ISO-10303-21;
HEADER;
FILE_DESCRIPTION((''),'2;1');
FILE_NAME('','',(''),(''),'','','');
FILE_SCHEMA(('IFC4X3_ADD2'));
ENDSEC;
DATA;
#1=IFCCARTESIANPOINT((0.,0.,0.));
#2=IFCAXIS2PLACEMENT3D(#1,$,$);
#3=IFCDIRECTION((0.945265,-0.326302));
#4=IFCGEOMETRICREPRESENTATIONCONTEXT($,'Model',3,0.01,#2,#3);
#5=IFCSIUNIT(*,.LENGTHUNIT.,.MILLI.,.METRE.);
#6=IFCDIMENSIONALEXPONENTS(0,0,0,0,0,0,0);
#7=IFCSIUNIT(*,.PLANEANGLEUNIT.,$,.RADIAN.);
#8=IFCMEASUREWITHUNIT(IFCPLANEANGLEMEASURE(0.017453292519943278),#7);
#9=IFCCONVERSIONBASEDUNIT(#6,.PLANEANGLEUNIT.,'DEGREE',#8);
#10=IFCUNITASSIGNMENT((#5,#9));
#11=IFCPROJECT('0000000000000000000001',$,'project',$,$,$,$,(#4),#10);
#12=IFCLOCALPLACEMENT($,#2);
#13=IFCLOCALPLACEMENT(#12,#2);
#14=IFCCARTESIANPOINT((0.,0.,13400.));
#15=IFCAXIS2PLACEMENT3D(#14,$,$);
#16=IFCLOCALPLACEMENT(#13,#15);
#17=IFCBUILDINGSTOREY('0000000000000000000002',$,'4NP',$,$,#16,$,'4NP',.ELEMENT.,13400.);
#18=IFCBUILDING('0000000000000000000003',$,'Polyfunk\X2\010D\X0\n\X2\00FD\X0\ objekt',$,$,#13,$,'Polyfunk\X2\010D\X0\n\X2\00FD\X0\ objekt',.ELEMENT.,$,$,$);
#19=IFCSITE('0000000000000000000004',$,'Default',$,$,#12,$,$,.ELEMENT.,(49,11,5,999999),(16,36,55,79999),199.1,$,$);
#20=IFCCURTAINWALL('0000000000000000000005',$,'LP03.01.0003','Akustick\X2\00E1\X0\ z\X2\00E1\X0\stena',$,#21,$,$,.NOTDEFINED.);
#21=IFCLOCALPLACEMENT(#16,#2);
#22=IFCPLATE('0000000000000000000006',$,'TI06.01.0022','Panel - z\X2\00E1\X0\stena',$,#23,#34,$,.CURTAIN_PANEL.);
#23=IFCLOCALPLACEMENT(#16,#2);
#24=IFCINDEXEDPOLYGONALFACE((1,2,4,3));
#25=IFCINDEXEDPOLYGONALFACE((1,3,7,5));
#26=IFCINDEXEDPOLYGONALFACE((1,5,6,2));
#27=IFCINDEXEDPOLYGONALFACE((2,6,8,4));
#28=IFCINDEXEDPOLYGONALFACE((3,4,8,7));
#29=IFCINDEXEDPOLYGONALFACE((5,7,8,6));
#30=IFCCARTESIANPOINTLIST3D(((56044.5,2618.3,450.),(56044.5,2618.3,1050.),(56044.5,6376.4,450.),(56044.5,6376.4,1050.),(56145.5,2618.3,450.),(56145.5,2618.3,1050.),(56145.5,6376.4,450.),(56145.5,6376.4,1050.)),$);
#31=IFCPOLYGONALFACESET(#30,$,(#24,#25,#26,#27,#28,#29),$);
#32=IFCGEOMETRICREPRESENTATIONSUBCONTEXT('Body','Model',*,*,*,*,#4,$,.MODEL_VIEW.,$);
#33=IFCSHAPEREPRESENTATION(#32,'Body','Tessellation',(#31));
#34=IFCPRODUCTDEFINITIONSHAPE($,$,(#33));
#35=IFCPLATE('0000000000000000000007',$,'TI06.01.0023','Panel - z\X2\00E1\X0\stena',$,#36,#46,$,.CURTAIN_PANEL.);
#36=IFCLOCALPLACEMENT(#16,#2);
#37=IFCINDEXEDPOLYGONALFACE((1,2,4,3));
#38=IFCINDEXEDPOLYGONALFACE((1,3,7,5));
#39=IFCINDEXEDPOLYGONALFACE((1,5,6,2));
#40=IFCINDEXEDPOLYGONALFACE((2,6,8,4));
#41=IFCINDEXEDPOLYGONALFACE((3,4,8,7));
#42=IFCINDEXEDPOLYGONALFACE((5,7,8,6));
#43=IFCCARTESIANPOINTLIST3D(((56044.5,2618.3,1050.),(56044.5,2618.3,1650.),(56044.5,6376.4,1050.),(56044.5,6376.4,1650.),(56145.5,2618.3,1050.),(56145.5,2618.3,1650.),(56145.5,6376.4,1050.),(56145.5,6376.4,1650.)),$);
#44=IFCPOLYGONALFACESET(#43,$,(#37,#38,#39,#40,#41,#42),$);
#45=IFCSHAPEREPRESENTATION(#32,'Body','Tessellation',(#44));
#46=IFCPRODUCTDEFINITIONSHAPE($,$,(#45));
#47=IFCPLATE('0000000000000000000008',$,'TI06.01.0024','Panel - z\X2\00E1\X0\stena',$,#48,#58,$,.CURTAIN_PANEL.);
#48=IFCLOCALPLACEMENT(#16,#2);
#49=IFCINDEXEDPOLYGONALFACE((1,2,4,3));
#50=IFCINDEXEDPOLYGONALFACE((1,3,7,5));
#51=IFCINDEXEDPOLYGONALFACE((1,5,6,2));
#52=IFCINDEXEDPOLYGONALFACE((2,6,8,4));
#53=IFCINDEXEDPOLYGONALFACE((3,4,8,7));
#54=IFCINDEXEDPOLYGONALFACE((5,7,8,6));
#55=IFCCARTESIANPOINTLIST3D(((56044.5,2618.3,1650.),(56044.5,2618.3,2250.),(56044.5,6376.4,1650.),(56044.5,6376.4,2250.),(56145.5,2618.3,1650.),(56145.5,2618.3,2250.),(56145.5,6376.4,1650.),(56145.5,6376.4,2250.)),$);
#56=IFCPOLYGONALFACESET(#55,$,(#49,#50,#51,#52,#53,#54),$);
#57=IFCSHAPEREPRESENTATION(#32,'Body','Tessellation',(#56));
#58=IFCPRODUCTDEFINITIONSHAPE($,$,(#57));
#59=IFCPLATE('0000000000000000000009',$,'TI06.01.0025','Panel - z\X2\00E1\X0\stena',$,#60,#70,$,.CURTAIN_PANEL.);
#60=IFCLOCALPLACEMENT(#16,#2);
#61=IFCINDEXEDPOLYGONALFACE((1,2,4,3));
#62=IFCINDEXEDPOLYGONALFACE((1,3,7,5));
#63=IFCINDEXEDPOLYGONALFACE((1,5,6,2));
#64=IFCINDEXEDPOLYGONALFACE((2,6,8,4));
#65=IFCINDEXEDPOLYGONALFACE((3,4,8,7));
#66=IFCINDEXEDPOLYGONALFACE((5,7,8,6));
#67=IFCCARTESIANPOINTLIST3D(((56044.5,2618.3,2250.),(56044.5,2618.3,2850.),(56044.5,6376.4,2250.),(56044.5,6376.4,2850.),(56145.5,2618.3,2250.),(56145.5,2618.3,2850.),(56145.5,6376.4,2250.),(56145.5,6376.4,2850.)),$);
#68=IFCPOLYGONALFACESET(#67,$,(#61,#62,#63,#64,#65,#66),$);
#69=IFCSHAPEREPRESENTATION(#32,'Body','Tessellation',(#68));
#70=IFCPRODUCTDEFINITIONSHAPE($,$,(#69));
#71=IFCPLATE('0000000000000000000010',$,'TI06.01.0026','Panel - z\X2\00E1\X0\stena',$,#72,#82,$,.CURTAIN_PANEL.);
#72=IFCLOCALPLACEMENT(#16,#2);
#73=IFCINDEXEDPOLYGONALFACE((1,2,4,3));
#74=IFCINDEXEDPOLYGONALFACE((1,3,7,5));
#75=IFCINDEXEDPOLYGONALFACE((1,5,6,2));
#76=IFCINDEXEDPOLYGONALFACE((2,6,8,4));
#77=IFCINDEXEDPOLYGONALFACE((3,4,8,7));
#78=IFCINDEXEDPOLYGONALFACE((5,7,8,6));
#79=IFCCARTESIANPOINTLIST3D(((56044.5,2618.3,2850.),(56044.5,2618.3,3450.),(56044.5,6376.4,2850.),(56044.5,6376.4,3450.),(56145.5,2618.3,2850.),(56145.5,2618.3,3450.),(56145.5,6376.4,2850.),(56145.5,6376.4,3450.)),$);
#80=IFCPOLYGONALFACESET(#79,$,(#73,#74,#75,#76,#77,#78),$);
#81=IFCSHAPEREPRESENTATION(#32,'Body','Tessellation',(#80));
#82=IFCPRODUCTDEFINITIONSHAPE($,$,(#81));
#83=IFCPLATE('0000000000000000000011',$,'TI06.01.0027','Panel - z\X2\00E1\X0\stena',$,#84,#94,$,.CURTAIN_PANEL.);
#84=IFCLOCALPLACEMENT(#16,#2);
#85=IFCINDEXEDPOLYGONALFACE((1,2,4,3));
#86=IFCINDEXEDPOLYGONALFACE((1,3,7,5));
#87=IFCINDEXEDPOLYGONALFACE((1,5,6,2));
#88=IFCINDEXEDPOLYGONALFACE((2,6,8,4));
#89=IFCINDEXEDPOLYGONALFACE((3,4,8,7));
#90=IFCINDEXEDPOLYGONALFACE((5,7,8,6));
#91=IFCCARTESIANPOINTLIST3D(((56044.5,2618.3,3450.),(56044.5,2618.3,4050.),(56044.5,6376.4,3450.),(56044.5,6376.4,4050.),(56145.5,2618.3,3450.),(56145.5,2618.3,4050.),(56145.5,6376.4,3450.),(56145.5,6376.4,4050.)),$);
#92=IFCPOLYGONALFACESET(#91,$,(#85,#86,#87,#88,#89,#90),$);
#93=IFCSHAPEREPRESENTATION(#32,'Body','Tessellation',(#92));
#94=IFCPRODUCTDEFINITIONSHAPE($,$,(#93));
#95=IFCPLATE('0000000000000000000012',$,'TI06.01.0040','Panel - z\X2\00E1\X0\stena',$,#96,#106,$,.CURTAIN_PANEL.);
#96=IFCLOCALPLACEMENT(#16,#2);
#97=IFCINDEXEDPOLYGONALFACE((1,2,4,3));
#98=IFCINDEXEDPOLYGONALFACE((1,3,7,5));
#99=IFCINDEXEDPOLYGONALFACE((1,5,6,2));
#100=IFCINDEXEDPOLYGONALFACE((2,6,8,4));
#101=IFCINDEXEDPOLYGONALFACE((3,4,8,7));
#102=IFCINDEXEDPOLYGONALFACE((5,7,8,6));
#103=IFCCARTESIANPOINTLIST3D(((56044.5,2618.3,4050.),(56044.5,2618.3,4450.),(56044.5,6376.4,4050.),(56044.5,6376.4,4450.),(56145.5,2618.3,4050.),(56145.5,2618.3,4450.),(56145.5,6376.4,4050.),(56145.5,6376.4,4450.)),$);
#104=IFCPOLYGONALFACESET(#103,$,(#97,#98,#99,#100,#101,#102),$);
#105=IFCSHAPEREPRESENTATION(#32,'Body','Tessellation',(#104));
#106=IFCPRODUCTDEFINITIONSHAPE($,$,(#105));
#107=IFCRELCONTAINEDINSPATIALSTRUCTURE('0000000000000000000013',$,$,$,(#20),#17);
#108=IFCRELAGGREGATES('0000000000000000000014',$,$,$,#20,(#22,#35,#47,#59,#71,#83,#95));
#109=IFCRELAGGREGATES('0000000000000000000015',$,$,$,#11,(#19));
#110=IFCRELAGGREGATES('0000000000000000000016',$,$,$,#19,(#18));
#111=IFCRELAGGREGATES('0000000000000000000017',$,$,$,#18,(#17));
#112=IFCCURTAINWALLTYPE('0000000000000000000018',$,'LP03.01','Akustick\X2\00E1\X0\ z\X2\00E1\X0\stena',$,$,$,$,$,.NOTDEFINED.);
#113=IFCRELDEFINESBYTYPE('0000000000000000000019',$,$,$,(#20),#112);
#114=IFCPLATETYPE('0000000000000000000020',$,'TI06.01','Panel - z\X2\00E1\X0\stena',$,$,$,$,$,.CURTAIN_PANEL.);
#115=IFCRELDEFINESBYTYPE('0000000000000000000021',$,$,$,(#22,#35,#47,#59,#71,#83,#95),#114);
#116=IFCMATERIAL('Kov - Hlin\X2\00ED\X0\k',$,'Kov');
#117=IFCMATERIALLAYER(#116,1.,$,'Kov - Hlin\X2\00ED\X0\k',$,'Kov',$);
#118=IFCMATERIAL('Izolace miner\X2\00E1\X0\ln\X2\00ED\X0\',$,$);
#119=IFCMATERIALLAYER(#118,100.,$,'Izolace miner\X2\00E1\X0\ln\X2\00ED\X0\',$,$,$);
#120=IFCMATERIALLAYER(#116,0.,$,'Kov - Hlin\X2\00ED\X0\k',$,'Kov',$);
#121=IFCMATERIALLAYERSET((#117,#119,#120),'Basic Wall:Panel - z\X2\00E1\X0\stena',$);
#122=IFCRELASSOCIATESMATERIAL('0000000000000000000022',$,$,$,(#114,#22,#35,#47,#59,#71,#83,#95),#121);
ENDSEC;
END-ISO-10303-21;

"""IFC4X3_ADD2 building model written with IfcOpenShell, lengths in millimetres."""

from ifc_helpers import new_model, entity, si_unit, converted_unit, direction, frame, frame_2d, origin, place, context, subcontext, project, spatial, rectangle, extrude, material, layer, layer_set, layer_usage, type_object, element, aggregate, save


model = new_model("IFC4X3_ADD2")

# Units and contexts
model_context = context("Model", 3, precision=0.01, world=origin(), true_north=direction((0.945265, -0.326302)))
body_context = subcontext(model_context, "Body", "Model", "MODEL_VIEW")
ifc_project = project(units=[si_unit("LENGTHUNIT", "METRE", prefix="MILLI"), converted_unit("PLANEANGLEUNIT", "DEGREE", entity("IfcPlaneAngleMeasure", 0.017453292519943278), si_unit("PLANEANGLEUNIT", "RADIAN"), dimensions=[0, 0, 0, 0, 0, 0, 0])], contexts=[model_context])

# Site, building, storey
site_placement = place(None, origin())
site = spatial("IfcSite", under=ifc_project, at=site_placement, Name="Default", CompositionType="ELEMENT", RefLatitude=(49, 11, 5, 999999), RefLongitude=(16, 36, 55, 79999), RefElevation=199.1)
building_placement = place(site_placement, origin())
building = spatial("IfcBuilding", under=site, at=building_placement, Name="Polyfunkčný objekt", LongName="Polyfunkčný objekt", CompositionType="ELEMENT")
storey_placement = place(building_placement, frame((0.0, 0.0, 13400.0)))
storey = spatial("IfcBuildingStorey", under=building, at=storey_placement, Name="4NP", LongName="4NP", CompositionType="ELEMENT", Elevation=13400.0)

# Shared definitions
curtain_wall_type = type_object("IfcCurtainWallType", Name="LP03.01", Description="Akustická zástena", PredefinedType="NOTDEFINED")

# Curtain wall, plates
curtain_wall_1_placement = place(storey_placement, frame((0.0, 0.0, -13400.0)))
curtain_wall_1 = element("IfcCurtainWall", 1, at=curtain_wall_1_placement, inside=storey, type_object=curtain_wall_type, Name="LP03.01.0003", Description="Akustická zástena", PredefinedType="NOTDEFINED")
ifc_material_1 = material(Name="Kov - Hliník", Category="Kov")
ifc_layer_1 = layer(ifc_material_1, 1.0, Name="Kov - Hliník", Category="Kov")
ifc_material_2 = material(Name="Izolace minerální")
ifc_layer_2 = layer(ifc_material_2, 100.0, Name="Izolace minerální")
ifc_layer_3 = layer(ifc_material_1, 0.0, Name="Kov - Hliník", Category="Kov")
ifc_layer_set = layer_set([ifc_layer_1, ifc_layer_2, ifc_layer_3], Name="Basic Wall:Panel - zástena")
ifc_layer_usage_1 = layer_usage(ifc_layer_set, "AXIS2", "NEGATIVE", 50.5)
plate_type = type_object("IfcPlateType", Name="TI06.01", Description="Panel - zástena", PredefinedType="CURTAIN_PANEL", material=ifc_layer_set)
plate_1_placement = place(storey_placement, frame((56095.0, 2618.3, 450.0), z_axis=(0.0, 0.0, 1.0), x_axis=(0.0, 1.0, 0.0)))
plate_1 = element("IfcPlate", 2, at=plate_1_placement, type_object=plate_type, material=ifc_layer_usage_1, Name="TI06.01.0022", Description="Panel - zástena", PredefinedType="CURTAIN_PANEL", context=body_context, shape_type="SweptSolid", body=[
    extrude(rectangle(XDim=101.0, YDim=3758.1, at=frame_2d((0.0, 0.0), x_axis=(1.0, 0.0))), frame((1879.0, 0.0, 0.0), z_axis=(0.0, 0.0, 1.0), x_axis=(0.0, 1.0, 0.0)), (0.0, 0.0, 1.0), 600.0),
])
ifc_layer_usage_2 = layer_usage(ifc_layer_set, "AXIS2", "NEGATIVE", 50.5)
plate_2_placement = place(storey_placement, frame((56095.0, 2618.3, 1050.0), z_axis=(0.0, 0.0, 1.0), x_axis=(0.0, 1.0, 0.0)))
plate_2 = element("IfcPlate", 3, at=plate_2_placement, type_object=plate_type, material=ifc_layer_usage_2, Name="TI06.01.0023", Description="Panel - zástena", PredefinedType="CURTAIN_PANEL", context=body_context, shape_type="SweptSolid", body=[
    extrude(rectangle(XDim=101.0, YDim=3758.1, at=frame_2d((0.0, 0.0), x_axis=(1.0, 0.0))), frame((1879.0, 0.0, 0.0), z_axis=(0.0, 0.0, 1.0), x_axis=(0.0, 1.0, 0.0)), (0.0, 0.0, 1.0), 600.0),
])
ifc_layer_usage_3 = layer_usage(ifc_layer_set, "AXIS2", "NEGATIVE", 50.5)
plate_3_placement = place(storey_placement, frame((56095.0, 2618.3, 1650.0), z_axis=(0.0, 0.0, 1.0), x_axis=(0.0, 1.0, 0.0)))
plate_3 = element("IfcPlate", 4, at=plate_3_placement, type_object=plate_type, material=ifc_layer_usage_3, Name="TI06.01.0024", Description="Panel - zástena", PredefinedType="CURTAIN_PANEL", context=body_context, shape_type="SweptSolid", body=[
    extrude(rectangle(XDim=101.0, YDim=3758.1, at=frame_2d((0.0, 0.0), x_axis=(1.0, 0.0))), frame((1879.0, 0.0, 0.0), z_axis=(0.0, 0.0, 1.0), x_axis=(0.0, 1.0, 0.0)), (0.0, 0.0, 1.0), 600.0),
])
ifc_layer_usage_4 = layer_usage(ifc_layer_set, "AXIS2", "NEGATIVE", 50.5)
plate_4_placement = place(storey_placement, frame((56095.0, 2618.3, 2250.0), z_axis=(0.0, 0.0, 1.0), x_axis=(0.0, 1.0, 0.0)))
plate_4 = element("IfcPlate", 5, at=plate_4_placement, type_object=plate_type, material=ifc_layer_usage_4, Name="TI06.01.0025", Description="Panel - zástena", PredefinedType="CURTAIN_PANEL", context=body_context, shape_type="SweptSolid", body=[
    extrude(rectangle(XDim=101.0, YDim=3758.1, at=frame_2d((0.0, 0.0), x_axis=(1.0, 0.0))), frame((1879.0, 0.0, 0.0), z_axis=(0.0, 0.0, 1.0), x_axis=(0.0, 1.0, 0.0)), (0.0, 0.0, 1.0), 600.0),
])
ifc_layer_usage_5 = layer_usage(ifc_layer_set, "AXIS2", "NEGATIVE", 50.5)
plate_5_placement = place(storey_placement, frame((56095.0, 2618.3, 2850.0), z_axis=(0.0, 0.0, 1.0), x_axis=(0.0, 1.0, 0.0)))
plate_5 = element("IfcPlate", 6, at=plate_5_placement, type_object=plate_type, material=ifc_layer_usage_5, Name="TI06.01.0026", Description="Panel - zástena", PredefinedType="CURTAIN_PANEL", context=body_context, shape_type="SweptSolid", body=[
    extrude(rectangle(XDim=101.0, YDim=3758.1, at=frame_2d((0.0, 0.0), x_axis=(1.0, 0.0))), frame((1879.0, 0.0, 0.0), z_axis=(0.0, 0.0, 1.0), x_axis=(0.0, 1.0, 0.0)), (0.0, 0.0, 1.0), 600.0),
])
ifc_layer_usage_6 = layer_usage(ifc_layer_set, "AXIS2", "NEGATIVE", 50.5)
plate_6_placement = place(storey_placement, frame((56095.0, 2618.3, 3450.0), z_axis=(0.0, 0.0, 1.0), x_axis=(0.0, 1.0, 0.0)))
plate_6 = element("IfcPlate", 7, at=plate_6_placement, type_object=plate_type, material=ifc_layer_usage_6, Name="TI06.01.0027", Description="Panel - zástena", PredefinedType="CURTAIN_PANEL", context=body_context, shape_type="SweptSolid", body=[
    extrude(rectangle(XDim=101.0, YDim=3758.1, at=frame_2d((0.0, 0.0), x_axis=(1.0, 0.0))), frame((1879.0, 0.0, 0.0), z_axis=(0.0, 0.0, 1.0), x_axis=(0.0, 1.0, 0.0)), (0.0, 0.0, 1.0), 600.0),
])
ifc_layer_usage_7 = layer_usage(ifc_layer_set, "AXIS2", "NEGATIVE", 50.5)
plate_7_placement = place(storey_placement, frame((56095.0, 2618.3, 4050.0), z_axis=(0.0, 0.0, 1.0), x_axis=(0.0, 1.0, 0.0)))
plate_7 = element("IfcPlate", 8, at=plate_7_placement, type_object=plate_type, material=ifc_layer_usage_7, Name="TI06.01.0040", Description="Panel - zástena", PredefinedType="CURTAIN_PANEL", context=body_context, shape_type="SweptSolid", body=[
    extrude(rectangle(XDim=101.0, YDim=3758.1, at=frame_2d((0.0, 0.0), x_axis=(1.0, 0.0))), frame((1879.0, 0.0, 0.0), z_axis=(0.0, 0.0, 1.0), x_axis=(0.0, 1.0, 0.0)), (0.0, 0.0, 1.0), 400.0),
])
aggregate(curtain_wall_1, [plate_1, plate_2, plate_3, plate_4, plate_5, plate_6, plate_7])

save(model, "model.ifc")
